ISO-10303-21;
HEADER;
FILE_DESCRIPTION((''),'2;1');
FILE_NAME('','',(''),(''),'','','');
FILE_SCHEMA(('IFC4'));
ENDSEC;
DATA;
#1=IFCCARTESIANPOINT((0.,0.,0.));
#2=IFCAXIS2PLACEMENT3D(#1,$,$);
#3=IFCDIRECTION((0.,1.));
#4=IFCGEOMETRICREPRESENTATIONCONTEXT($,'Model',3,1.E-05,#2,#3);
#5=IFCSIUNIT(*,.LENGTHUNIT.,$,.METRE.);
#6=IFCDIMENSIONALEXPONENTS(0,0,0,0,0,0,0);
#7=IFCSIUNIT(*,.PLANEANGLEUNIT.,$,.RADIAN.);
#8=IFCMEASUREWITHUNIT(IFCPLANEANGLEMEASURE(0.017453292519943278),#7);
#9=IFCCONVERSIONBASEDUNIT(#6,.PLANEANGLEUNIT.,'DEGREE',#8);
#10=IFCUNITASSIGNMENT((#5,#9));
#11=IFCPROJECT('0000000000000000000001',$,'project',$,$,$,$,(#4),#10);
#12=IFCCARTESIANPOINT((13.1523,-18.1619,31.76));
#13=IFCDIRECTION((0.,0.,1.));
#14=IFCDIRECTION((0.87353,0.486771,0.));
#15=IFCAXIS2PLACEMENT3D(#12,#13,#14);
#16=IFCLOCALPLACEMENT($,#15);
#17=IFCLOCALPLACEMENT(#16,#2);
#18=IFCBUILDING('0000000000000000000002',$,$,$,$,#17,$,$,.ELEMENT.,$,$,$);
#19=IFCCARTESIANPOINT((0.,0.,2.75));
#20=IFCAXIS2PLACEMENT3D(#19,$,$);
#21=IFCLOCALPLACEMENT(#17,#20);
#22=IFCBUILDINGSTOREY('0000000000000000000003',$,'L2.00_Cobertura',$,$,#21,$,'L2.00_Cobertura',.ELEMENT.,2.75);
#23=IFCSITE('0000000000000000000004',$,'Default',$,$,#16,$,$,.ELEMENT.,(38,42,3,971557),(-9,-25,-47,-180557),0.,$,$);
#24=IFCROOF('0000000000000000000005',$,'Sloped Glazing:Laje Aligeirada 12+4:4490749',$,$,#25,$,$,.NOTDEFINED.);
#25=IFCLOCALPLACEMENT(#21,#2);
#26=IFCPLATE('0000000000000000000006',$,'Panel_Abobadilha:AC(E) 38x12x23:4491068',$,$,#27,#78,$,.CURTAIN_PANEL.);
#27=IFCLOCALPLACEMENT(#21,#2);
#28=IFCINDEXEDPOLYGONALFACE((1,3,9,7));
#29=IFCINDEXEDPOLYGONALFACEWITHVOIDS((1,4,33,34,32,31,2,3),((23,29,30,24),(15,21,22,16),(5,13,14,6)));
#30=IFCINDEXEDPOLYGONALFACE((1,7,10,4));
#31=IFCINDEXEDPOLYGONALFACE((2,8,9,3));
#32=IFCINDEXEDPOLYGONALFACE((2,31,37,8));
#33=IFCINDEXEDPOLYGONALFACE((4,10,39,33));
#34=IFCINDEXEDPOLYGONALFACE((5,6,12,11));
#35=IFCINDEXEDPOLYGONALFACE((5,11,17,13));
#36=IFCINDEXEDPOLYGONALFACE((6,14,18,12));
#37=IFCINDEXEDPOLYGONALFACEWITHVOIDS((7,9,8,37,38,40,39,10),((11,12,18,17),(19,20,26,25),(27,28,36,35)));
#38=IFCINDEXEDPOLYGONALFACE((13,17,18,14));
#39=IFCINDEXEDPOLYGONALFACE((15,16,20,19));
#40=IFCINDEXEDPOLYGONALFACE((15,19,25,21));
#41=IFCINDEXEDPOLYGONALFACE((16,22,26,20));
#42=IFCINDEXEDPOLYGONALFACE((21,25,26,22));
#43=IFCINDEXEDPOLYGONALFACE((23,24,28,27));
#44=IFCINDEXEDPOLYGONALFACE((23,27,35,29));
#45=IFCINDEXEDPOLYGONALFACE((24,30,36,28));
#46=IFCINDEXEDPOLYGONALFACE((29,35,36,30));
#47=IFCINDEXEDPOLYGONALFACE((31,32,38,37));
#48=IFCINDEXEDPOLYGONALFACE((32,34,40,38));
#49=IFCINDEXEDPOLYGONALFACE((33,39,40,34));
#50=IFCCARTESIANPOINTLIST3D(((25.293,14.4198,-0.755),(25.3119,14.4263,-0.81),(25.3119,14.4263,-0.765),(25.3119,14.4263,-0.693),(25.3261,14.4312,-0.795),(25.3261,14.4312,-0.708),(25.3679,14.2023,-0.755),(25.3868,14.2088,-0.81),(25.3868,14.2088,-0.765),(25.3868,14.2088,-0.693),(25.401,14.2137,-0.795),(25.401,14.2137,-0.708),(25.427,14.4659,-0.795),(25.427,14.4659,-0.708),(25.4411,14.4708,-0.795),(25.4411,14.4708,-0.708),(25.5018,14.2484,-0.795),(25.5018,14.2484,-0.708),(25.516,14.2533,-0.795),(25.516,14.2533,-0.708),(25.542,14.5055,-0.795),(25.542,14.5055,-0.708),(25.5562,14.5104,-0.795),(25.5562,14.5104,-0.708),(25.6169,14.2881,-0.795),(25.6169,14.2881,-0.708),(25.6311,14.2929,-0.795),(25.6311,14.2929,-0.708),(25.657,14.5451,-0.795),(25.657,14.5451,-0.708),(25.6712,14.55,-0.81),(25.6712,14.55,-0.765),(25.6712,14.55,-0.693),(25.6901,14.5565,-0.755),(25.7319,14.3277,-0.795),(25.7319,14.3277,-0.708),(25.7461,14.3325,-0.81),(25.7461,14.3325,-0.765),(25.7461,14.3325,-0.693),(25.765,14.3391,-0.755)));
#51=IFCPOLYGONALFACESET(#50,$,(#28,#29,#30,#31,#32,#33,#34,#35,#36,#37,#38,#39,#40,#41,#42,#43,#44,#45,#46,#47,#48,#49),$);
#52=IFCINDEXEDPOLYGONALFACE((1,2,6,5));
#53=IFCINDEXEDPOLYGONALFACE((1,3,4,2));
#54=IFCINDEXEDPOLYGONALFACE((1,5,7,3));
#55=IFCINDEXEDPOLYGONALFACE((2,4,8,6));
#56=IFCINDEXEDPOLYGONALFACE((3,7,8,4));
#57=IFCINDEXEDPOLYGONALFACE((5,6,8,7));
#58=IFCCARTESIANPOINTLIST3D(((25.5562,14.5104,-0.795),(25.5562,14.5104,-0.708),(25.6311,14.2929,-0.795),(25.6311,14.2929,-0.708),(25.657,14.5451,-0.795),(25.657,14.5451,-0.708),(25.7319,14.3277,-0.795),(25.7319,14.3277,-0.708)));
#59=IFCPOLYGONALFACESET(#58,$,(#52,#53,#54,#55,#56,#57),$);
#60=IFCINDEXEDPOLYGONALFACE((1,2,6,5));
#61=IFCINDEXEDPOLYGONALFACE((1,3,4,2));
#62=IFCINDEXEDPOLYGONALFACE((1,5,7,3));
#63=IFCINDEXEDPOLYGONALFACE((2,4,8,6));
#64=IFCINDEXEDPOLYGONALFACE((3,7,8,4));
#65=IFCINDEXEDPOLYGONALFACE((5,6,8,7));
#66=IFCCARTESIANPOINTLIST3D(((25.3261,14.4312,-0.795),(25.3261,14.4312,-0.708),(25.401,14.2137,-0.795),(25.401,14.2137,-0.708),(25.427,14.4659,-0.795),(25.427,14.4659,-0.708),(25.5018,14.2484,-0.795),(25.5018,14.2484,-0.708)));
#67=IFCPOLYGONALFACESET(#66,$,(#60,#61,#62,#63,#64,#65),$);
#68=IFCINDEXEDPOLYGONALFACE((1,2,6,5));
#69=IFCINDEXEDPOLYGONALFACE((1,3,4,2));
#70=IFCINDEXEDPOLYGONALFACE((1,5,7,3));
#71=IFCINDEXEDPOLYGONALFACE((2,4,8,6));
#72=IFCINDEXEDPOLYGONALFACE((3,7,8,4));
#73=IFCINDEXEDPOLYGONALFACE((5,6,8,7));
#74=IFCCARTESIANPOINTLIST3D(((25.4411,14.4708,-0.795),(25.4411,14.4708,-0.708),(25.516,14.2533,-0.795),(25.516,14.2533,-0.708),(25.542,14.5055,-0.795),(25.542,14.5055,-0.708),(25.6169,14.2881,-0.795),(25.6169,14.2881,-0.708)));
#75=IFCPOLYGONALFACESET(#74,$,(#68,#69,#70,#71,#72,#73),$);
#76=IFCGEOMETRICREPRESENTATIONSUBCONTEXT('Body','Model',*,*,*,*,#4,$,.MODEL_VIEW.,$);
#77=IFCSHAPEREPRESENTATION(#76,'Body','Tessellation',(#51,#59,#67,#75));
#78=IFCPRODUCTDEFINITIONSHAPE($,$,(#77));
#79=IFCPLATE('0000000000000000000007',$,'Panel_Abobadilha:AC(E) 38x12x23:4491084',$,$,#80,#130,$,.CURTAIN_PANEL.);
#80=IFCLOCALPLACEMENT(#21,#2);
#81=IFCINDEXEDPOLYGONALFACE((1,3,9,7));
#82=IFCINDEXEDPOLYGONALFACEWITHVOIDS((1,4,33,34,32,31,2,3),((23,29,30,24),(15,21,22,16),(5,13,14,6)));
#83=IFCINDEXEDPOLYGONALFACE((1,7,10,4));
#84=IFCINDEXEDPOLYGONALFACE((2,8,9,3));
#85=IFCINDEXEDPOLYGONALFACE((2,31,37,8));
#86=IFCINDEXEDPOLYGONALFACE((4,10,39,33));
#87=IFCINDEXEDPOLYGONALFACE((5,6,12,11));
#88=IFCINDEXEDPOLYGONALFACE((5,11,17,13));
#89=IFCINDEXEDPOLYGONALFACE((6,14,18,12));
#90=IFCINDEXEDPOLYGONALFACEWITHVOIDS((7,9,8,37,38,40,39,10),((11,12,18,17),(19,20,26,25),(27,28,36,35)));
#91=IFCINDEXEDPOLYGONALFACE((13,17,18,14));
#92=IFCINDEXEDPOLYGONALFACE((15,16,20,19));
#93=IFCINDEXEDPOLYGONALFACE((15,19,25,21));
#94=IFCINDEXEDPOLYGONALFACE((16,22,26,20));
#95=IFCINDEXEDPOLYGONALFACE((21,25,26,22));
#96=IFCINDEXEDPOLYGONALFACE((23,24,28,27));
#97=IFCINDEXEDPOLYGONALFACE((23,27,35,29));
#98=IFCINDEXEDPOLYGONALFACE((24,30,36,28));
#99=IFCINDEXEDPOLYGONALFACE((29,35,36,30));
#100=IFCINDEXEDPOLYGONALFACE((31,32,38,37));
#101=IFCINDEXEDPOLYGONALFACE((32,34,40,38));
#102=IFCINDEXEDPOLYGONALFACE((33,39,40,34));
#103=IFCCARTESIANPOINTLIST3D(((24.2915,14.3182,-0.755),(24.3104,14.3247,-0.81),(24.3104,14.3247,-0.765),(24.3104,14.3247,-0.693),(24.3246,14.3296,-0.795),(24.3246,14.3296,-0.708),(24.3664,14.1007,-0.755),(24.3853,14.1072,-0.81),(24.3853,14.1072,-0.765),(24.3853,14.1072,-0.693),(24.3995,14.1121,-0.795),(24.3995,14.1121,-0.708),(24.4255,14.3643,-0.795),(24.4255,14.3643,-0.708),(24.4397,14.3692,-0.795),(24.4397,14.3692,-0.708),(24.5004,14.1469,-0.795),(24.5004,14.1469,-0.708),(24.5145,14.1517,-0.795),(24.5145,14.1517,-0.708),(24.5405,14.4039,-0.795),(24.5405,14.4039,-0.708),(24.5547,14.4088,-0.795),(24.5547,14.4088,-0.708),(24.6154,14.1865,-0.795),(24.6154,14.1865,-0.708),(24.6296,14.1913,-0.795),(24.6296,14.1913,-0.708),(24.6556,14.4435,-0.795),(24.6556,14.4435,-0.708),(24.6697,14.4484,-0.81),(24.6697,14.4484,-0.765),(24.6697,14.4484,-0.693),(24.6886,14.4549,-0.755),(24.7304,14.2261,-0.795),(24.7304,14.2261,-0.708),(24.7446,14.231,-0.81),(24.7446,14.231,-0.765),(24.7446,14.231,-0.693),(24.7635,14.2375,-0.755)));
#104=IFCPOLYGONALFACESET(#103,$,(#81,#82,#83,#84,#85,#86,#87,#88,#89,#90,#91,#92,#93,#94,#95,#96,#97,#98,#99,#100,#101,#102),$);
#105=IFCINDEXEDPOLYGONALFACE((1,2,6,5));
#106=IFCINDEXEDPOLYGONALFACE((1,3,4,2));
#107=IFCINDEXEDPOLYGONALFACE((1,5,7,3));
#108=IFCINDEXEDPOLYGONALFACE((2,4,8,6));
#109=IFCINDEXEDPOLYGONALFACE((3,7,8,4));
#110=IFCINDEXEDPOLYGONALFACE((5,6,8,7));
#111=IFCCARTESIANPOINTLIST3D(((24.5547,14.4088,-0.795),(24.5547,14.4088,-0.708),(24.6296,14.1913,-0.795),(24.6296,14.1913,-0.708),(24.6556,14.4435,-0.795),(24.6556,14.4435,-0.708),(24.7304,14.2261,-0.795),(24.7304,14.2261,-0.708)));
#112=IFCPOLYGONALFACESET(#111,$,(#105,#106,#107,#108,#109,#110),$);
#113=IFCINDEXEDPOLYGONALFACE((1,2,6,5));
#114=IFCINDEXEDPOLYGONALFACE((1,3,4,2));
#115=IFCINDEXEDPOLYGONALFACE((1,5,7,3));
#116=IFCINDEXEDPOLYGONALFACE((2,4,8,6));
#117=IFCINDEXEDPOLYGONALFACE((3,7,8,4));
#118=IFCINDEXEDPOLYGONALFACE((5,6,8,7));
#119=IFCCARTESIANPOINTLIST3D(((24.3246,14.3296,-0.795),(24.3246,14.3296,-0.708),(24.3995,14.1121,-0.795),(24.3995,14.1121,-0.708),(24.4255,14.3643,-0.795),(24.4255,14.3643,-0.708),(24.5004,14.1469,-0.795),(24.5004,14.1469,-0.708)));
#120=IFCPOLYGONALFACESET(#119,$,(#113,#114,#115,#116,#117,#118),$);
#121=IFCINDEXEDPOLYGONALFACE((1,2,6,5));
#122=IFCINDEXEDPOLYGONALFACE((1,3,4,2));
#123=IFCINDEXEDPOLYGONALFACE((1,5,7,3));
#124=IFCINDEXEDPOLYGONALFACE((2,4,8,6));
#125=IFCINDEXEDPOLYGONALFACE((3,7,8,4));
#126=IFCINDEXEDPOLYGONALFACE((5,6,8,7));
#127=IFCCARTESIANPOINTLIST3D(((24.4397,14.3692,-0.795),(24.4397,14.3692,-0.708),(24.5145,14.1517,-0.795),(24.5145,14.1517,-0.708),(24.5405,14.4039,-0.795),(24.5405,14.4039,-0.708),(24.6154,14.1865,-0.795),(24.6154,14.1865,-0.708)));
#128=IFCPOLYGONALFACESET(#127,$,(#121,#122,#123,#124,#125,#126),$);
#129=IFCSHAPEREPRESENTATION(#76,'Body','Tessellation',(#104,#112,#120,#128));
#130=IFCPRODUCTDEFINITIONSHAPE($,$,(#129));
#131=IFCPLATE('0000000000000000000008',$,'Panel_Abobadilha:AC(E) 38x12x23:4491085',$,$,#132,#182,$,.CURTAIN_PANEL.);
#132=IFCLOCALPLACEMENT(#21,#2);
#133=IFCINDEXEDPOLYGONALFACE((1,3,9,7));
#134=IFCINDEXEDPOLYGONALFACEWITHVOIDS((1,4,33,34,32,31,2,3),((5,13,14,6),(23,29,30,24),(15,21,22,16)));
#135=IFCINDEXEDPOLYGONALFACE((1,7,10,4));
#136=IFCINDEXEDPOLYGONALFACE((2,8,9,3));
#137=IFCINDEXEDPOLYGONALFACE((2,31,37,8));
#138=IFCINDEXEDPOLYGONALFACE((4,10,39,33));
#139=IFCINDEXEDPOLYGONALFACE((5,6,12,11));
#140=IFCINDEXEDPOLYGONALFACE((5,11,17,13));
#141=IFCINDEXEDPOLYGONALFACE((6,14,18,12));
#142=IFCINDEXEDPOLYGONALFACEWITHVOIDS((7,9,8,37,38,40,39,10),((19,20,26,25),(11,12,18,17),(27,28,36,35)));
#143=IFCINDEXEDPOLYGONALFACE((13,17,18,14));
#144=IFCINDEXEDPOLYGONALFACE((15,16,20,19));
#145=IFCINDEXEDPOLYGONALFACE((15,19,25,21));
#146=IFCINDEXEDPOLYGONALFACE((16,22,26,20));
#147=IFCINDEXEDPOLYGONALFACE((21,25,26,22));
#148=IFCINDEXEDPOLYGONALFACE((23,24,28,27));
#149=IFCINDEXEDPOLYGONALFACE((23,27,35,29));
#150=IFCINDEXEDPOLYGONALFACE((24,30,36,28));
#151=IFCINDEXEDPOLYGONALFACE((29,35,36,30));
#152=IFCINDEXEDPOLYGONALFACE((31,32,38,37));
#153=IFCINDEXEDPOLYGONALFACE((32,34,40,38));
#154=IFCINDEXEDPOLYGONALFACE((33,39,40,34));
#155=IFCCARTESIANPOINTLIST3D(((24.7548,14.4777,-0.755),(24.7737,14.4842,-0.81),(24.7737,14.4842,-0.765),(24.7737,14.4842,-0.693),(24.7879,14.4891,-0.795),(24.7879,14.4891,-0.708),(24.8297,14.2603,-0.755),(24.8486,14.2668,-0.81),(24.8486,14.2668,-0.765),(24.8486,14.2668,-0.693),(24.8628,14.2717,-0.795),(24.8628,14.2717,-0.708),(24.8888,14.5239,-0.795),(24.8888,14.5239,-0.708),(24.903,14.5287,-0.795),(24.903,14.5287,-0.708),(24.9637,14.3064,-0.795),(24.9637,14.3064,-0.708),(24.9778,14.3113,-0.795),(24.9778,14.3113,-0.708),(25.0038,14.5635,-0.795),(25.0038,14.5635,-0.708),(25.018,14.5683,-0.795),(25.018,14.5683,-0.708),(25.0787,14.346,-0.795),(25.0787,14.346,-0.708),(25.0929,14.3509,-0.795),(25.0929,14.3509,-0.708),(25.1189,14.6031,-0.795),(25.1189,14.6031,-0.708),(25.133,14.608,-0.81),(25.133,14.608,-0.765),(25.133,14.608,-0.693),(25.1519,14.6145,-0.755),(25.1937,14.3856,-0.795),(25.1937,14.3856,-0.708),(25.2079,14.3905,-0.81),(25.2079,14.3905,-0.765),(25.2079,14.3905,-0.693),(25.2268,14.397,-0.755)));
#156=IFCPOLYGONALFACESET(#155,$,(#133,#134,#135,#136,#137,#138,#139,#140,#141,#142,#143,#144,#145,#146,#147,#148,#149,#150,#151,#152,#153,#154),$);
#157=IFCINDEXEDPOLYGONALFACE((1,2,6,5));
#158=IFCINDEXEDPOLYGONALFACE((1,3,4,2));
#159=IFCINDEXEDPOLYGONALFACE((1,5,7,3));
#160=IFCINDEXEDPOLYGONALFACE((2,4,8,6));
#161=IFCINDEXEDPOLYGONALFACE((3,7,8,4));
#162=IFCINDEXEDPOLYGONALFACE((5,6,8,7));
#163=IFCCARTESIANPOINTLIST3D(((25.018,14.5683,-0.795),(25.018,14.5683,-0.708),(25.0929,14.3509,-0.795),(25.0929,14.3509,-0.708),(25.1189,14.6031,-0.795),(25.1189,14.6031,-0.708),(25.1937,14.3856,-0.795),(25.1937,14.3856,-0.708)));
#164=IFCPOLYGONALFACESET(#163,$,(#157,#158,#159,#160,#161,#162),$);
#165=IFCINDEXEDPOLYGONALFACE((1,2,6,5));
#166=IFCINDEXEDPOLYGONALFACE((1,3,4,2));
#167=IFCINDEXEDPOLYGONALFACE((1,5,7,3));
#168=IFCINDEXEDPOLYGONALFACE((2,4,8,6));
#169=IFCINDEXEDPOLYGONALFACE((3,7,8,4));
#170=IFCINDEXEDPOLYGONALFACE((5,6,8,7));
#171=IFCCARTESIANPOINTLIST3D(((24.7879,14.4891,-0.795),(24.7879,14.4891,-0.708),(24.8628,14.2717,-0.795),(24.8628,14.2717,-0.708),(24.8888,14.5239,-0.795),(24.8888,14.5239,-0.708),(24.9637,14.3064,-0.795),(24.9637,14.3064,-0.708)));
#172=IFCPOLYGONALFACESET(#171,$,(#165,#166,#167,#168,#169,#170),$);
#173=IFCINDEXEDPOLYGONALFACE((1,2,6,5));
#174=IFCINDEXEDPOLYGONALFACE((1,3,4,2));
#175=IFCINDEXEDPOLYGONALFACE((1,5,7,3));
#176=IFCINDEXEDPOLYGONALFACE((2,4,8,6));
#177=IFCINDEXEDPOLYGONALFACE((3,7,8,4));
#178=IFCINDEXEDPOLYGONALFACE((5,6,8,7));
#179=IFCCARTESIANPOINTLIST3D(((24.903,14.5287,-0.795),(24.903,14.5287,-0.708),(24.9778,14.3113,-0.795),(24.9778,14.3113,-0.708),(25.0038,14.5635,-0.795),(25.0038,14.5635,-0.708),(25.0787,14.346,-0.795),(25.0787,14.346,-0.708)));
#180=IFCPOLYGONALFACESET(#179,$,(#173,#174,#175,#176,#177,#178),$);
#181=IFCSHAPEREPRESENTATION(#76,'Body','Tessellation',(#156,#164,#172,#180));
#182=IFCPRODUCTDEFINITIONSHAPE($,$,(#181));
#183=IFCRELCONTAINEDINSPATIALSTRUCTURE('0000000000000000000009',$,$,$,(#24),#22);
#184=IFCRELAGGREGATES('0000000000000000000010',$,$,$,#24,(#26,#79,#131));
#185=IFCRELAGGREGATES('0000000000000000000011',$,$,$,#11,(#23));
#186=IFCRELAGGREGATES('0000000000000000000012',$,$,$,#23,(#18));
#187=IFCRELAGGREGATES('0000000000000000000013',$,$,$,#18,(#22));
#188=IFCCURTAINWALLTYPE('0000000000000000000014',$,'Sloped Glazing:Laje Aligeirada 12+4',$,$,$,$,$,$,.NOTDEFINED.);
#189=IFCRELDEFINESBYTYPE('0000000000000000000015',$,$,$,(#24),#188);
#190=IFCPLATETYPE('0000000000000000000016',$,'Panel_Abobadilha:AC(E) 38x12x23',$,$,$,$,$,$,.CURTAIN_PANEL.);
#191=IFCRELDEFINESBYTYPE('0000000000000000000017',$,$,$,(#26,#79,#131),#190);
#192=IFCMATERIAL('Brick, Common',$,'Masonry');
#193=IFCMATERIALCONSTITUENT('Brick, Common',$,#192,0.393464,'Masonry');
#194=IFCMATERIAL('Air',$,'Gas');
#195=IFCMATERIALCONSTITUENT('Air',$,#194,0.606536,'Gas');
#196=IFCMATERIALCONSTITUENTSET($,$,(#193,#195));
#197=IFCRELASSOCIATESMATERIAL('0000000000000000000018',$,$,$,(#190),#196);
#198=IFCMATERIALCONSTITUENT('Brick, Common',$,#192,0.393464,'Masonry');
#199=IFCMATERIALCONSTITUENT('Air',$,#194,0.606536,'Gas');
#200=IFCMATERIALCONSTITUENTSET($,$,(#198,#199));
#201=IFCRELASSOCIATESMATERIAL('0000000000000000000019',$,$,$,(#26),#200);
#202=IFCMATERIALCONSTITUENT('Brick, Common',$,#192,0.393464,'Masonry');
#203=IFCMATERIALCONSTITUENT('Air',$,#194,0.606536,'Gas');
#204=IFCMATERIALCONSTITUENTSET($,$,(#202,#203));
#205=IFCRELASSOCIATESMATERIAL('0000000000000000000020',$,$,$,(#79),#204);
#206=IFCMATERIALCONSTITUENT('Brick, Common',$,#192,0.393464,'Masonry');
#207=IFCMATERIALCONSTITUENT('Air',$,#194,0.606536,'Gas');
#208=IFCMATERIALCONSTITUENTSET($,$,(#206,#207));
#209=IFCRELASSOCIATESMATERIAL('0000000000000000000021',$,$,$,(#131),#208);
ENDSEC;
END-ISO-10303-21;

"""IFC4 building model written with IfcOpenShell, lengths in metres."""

from ifc_helpers import new_model, entity, si_unit, converted_unit, direction, frame, origin, place, context, subcontext, project, spatial, indexed_curve, outline, extrude, source, transform, mapped, material, constituent, constituent_set, type_object, type_shapes, element, aggregate, save


model = new_model("IFC4")

# Units and contexts
model_context = context("Model", 3, precision=1e-05, world=origin(), true_north=direction((0.0, 1.0)))
body_context = subcontext(model_context, "Body", "Model", "MODEL_VIEW")
ifc_project = project(units=[si_unit("LENGTHUNIT", "METRE"), converted_unit("PLANEANGLEUNIT", "DEGREE", entity("IfcPlaneAngleMeasure", 0.017453292519943278), si_unit("PLANEANGLEUNIT", "RADIAN"), dimensions=[0, 0, 0, 0, 0, 0, 0])], contexts=[model_context])

# Site, building, storey
site_placement = place(None, frame((13.1523, -18.1619, 31.76), z_axis=(0.0, 0.0, 1.0), x_axis=(0.87353, 0.486771, 0.0)))
site = spatial("IfcSite", under=ifc_project, at=site_placement, Name="Default", CompositionType="ELEMENT", RefLatitude=(38, 42, 3, 971557), RefLongitude=(-9, -25, -47, -180557), RefElevation=0.0)
building_placement = place(site_placement, origin())
building = spatial("IfcBuilding", under=site, at=building_placement, CompositionType="ELEMENT")
storey_placement = place(building_placement, frame((0.0, 0.0, 2.75)))
storey = spatial("IfcBuildingStorey", under=building, at=storey_placement, Name="L2.00_Cobertura", LongName="L2.00_Cobertura", CompositionType="ELEMENT", Elevation=2.75)

# Roof, plates
curtain_wall_type = type_object("IfcCurtainWallType", Name="Sloped Glazing:Laje Aligeirada 12+4", PredefinedType="NOTDEFINED")
roof_placement = place(storey_placement, frame((0.0, 0.0, -2.75)))
roof = element("IfcRoof", 1, at=roof_placement, inside=storey, type_object=curtain_wall_type, Name="Sloped Glazing:Laje Aligeirada 12+4:4490749", PredefinedType="NOTDEFINED")
ifc_material_1 = material(Name="Brick, Common", Category="Masonry")
ifc_material_2 = material(Name="Air", Category="Gas")
ifc_constituent_1 = constituent(ifc_material_1, Name="Brick, Common", Category="Masonry", fraction=0.393464)
ifc_constituent_2 = constituent(ifc_material_2, Name="Air", Category="Gas", fraction=0.606536)
ifc_constituent_set_1 = constituent_set(constituents=[ifc_constituent_1, ifc_constituent_2])
plate_type = type_object("IfcPlateType", Name="Panel_Abobadilha:AC(E) 38x12x23", PredefinedType="CURTAIN_PANEL", material=ifc_constituent_set_1)
shared_shape_1 = source(origin(), body_context, "Body", "SweptSolid", [
    extrude(outline(indexed_curve([(-0.19, -0.0543), (0.19, -0.0543), (0.19, -0.0093), (0.21, 0.0007), (0.19, 0.0628), (-0.19, 0.0628), (-0.21, 0.0007), (-0.19, -0.0093), (-0.19, -0.0543)], self_intersect=False), holes=[indexed_curve([(-0.0683, 0.0477), (-0.0683, -0.0393), (-0.175, -0.0393), (-0.175, 0.0477), (-0.0683, 0.0477)], self_intersect=False), indexed_curve([(0.0533, 0.0477), (0.0533, -0.0393), (-0.0533, -0.0393), (-0.0533, 0.0477), (0.0533, 0.0477)], self_intersect=False), indexed_curve([(0.175, 0.0477), (0.175, -0.0393), (0.0683, -0.0393), (0.0683, 0.0477), (0.175, 0.0477)], self_intersect=False)]), frame((0.0, 0.0543, 0.0)), (0.0, 0.0, 1.0), 0.23),
    extrude(outline(indexed_curve([(-0.0533, -0.0435), (0.0533, -0.0435), (0.0533, 0.0435), (-0.0533, 0.0435), (-0.0533, -0.0435)], self_intersect=False)), frame((0.1217, 0.0585, 0.0), z_axis=(0.0, 0.0, 1.0), x_axis=(-1.0, 0.0, 0.0)), (0.0, 0.0, 1.0), 0.23),
    extrude(outline(indexed_curve([(-0.0533, -0.0435), (0.0533, -0.0435), (0.0533, 0.0435), (-0.0533, 0.0435), (-0.0533, -0.0435)], self_intersect=False)), frame((-0.1217, 0.0585, 0.0), z_axis=(0.0, 0.0, 1.0), x_axis=(-1.0, 0.0, 0.0)), (0.0, 0.0, 1.0), 0.23),
    extrude(outline(indexed_curve([(-0.0533, -0.0435), (0.0533, -0.0435), (0.0533, 0.0435), (-0.0533, 0.0435), (-0.0533, -0.0435)], self_intersect=False)), frame((0.0, 0.0585, 0.0), z_axis=(0.0, 0.0, 1.0), x_axis=(-1.0, 0.0, 0.0)), (0.0, 0.0, 1.0), 0.23),
])
type_shapes(plate_type, [shared_shape_1])
ifc_constituent_3 = constituent(ifc_material_1, Name="Brick, Common", Category="Masonry", fraction=0.393464)
ifc_constituent_4 = constituent(ifc_material_2, Name="Air", Category="Gas", fraction=0.606536)
ifc_constituent_set_2 = constituent_set(constituents=[ifc_constituent_3, ifc_constituent_4])
plate_1_placement = place(roof_placement, frame((25.4916, 14.4882, 1.94), z_axis=(0.325568, -0.945519, 0.0), x_axis=(0.945519, 0.325568, 0.0)))
plate_1 = element("IfcPlate", 2, at=plate_1_placement, type_object=plate_type, material=ifc_constituent_set_2, Name="Panel_Abobadilha:AC(E) 38x12x23:4491068", PredefinedType="CURTAIN_PANEL", context=body_context, shape_type="MappedRepresentation", body=[
    mapped(shared_shape_1, transform((0.0, 0.0, 0.0), scale=1.0)),
])
ifc_constituent_5 = constituent(ifc_material_1, Name="Brick, Common", Category="Masonry", fraction=0.393464)
ifc_constituent_6 = constituent(ifc_material_2, Name="Air", Category="Gas", fraction=0.606536)
ifc_constituent_set_3 = constituent_set(constituents=[ifc_constituent_5, ifc_constituent_6])
plate_2_placement = place(roof_placement, frame((24.4901, 14.3866, 1.94), z_axis=(0.325568, -0.945519, 0.0), x_axis=(0.945519, 0.325568, 0.0)))
plate_2 = element("IfcPlate", 3, at=plate_2_placement, type_object=plate_type, material=ifc_constituent_set_3, Name="Panel_Abobadilha:AC(E) 38x12x23:4491084", PredefinedType="CURTAIN_PANEL", context=body_context, shape_type="MappedRepresentation", body=[
    mapped(shared_shape_1, transform((0.0, 0.0, 0.0), scale=1.0)),
])
ifc_constituent_7 = constituent(ifc_material_1, Name="Brick, Common", Category="Masonry", fraction=0.393464)
ifc_constituent_8 = constituent(ifc_material_2, Name="Air", Category="Gas", fraction=0.606536)
ifc_constituent_set_4 = constituent_set(constituents=[ifc_constituent_7, ifc_constituent_8])
plate_3_placement = place(roof_placement, frame((24.9534, 14.5461, 1.94), z_axis=(0.325568, -0.945519, 0.0), x_axis=(0.945519, 0.325568, 0.0)))
plate_3 = element("IfcPlate", 4, at=plate_3_placement, type_object=plate_type, material=ifc_constituent_set_4, Name="Panel_Abobadilha:AC(E) 38x12x23:4491085", PredefinedType="CURTAIN_PANEL", context=body_context, shape_type="MappedRepresentation", body=[
    mapped(shared_shape_1, transform((0.0, 0.0, 0.0), scale=1.0)),
])
aggregate(roof, [plate_1, plate_2, plate_3])

save(model, "model.ifc")
